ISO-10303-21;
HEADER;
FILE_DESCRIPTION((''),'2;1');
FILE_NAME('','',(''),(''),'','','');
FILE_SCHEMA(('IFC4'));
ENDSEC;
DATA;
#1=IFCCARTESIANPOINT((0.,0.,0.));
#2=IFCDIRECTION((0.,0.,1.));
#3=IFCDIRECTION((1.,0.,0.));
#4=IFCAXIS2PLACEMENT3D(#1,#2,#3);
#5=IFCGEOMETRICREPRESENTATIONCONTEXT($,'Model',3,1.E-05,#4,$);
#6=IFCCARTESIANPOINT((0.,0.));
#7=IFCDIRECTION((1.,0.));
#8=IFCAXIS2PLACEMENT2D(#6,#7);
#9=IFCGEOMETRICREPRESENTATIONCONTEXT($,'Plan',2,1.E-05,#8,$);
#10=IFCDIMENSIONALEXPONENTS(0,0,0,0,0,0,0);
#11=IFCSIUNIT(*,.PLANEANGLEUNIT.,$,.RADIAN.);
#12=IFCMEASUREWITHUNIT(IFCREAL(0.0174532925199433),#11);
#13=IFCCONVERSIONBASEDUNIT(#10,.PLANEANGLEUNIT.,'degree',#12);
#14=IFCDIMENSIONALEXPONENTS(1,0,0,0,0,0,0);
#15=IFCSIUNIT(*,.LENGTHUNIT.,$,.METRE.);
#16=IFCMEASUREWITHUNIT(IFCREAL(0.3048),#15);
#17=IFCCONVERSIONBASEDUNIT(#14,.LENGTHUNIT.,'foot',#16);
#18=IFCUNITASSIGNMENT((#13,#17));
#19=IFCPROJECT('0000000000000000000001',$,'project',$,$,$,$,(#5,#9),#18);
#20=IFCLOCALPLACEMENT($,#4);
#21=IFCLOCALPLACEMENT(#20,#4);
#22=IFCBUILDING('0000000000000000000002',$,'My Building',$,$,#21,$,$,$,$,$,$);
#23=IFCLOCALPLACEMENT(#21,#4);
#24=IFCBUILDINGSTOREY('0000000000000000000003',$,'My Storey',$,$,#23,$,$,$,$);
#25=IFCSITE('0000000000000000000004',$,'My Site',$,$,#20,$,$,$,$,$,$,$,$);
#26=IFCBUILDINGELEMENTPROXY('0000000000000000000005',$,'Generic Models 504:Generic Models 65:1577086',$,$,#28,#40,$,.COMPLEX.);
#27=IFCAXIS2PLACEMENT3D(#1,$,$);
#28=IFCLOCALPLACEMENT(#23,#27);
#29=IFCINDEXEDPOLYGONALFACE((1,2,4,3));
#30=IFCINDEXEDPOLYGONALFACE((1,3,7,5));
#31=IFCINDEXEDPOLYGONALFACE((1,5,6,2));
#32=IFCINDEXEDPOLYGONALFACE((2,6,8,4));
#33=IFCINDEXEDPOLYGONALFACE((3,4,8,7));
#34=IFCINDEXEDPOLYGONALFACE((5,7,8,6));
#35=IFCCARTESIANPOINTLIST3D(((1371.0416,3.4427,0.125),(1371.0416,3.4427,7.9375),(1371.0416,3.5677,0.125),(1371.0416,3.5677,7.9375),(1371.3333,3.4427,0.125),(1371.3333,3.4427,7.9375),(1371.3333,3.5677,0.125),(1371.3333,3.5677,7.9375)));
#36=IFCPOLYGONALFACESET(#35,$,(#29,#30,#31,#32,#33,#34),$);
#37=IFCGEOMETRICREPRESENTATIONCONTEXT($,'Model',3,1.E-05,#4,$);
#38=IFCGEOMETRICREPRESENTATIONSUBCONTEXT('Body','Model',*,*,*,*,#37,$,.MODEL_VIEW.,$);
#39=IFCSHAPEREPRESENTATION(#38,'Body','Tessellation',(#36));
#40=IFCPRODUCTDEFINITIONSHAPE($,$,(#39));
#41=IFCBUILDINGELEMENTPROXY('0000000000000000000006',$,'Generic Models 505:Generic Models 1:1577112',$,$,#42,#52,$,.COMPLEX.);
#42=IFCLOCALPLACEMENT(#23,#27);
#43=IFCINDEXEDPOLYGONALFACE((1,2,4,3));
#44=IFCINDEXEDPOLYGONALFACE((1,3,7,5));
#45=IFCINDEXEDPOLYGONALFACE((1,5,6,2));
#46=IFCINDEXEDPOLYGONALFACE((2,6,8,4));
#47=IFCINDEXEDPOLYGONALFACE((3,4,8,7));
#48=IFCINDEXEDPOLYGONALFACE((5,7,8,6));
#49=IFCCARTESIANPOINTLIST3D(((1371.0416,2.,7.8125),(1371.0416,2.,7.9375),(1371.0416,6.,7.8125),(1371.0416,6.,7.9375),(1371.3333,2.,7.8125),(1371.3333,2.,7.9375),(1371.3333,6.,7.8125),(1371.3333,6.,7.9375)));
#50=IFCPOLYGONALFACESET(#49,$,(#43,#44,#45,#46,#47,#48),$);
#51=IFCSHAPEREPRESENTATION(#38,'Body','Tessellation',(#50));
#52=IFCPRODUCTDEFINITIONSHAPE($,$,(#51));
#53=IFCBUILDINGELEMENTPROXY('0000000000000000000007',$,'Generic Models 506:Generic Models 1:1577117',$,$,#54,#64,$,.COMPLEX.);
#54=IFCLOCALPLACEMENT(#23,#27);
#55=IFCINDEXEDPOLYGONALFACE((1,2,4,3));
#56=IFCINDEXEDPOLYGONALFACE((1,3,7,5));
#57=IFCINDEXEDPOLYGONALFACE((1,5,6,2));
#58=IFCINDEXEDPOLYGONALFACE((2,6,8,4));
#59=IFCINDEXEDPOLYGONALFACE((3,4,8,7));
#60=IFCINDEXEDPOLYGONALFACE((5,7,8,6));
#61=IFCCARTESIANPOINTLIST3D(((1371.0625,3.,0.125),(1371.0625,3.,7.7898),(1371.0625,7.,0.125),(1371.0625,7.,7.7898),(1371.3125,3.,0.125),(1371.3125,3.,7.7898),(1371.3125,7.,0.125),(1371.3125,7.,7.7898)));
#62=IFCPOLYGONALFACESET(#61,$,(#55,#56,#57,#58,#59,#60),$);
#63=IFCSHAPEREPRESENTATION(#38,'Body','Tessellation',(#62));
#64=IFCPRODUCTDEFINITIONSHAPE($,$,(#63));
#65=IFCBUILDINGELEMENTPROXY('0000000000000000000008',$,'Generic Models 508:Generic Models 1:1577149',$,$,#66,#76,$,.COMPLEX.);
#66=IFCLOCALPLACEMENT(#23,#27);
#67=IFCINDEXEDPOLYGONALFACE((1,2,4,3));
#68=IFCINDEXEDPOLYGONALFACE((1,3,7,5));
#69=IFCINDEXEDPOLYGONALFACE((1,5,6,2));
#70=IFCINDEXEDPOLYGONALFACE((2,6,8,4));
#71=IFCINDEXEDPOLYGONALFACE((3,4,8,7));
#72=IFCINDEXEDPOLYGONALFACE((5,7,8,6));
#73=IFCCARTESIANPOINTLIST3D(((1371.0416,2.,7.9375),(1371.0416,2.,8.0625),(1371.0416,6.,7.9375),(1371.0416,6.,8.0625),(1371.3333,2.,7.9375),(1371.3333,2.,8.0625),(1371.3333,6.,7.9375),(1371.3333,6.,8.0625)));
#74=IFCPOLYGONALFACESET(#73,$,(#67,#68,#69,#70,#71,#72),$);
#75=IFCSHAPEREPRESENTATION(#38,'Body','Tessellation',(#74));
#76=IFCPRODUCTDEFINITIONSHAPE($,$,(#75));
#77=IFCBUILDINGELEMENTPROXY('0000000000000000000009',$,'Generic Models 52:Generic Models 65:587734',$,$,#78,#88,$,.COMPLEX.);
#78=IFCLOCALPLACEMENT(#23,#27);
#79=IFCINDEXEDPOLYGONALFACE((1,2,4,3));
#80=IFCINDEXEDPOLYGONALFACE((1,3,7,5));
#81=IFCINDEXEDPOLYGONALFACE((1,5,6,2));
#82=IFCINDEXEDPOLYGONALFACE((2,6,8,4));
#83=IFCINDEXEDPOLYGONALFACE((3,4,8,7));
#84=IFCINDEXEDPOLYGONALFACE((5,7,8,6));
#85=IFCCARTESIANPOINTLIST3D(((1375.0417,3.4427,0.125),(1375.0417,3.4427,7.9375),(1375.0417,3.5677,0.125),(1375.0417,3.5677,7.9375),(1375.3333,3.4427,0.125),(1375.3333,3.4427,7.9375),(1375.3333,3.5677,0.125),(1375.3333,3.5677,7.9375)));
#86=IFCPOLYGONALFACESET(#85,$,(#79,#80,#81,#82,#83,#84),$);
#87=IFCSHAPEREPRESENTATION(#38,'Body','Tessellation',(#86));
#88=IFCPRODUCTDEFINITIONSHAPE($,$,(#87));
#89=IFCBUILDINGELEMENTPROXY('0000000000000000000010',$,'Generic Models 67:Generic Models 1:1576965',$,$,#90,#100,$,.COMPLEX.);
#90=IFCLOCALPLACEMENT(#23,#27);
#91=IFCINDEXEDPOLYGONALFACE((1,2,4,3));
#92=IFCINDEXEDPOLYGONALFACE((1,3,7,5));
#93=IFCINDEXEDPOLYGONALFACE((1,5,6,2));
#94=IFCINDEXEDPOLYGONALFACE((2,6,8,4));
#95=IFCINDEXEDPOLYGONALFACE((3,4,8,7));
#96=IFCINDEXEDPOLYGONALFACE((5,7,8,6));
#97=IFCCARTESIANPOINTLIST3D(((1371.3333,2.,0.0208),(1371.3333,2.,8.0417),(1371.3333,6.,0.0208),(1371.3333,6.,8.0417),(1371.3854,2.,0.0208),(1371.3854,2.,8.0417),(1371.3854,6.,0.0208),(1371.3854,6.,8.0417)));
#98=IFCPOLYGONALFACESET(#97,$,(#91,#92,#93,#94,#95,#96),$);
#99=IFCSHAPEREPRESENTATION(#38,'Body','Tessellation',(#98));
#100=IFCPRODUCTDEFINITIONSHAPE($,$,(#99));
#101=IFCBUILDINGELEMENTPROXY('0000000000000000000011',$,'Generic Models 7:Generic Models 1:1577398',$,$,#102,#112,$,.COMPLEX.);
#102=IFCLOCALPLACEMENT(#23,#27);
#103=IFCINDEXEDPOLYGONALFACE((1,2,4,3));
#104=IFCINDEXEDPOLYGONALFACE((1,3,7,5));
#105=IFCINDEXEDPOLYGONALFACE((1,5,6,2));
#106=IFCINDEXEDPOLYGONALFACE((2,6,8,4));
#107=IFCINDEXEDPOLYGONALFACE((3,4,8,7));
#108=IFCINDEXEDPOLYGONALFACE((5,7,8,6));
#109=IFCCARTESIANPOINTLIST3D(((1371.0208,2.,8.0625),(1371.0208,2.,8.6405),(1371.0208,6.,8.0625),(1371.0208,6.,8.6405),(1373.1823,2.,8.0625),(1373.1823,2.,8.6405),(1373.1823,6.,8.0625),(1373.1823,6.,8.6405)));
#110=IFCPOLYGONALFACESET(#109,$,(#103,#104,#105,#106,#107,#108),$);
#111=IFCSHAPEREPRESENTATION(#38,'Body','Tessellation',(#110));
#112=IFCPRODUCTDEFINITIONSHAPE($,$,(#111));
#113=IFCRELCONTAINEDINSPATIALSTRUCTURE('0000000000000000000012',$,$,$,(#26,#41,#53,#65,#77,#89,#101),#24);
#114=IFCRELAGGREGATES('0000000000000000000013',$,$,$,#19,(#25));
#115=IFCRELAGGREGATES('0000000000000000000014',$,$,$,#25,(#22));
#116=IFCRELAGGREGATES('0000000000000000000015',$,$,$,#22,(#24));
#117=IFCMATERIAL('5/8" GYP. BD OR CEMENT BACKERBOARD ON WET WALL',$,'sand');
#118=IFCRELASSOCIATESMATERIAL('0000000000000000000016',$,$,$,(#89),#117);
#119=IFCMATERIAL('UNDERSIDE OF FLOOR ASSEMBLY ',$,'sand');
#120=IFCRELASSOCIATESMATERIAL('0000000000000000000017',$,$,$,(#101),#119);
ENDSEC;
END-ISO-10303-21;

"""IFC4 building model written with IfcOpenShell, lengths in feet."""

from ifc_helpers import new_model, entity, si_unit, converted_unit, frame, origin_with_axes, origin_2d_with_axis, place, context, subcontext, project, spatial, polyline, outline, extrude, material, element, save


model = new_model("IFC4")

# Units and contexts
model_context_1 = context("Model", 3, precision=1e-05, world=origin_with_axes())
plan_context = context("Plan", 2, precision=1e-05, world=origin_2d_with_axis())
model_context_2 = context("Model", 3, precision=1e-05, world=origin_with_axes())
body_context = subcontext(model_context_2, "Body", "Model", "MODEL_VIEW")
ifc_project = project(units=[converted_unit("PLANEANGLEUNIT", "degree", entity("IfcReal", 0.0174532925199433), si_unit("PLANEANGLEUNIT", "RADIAN"), dimensions=[0, 0, 0, 0, 0, 0, 0]), converted_unit("LENGTHUNIT", "foot", entity("IfcReal", 0.3048), si_unit("LENGTHUNIT", "METRE"), dimensions=[1, 0, 0, 0, 0, 0, 0])], contexts=[model_context_1, plan_context])

# Site, building, storey
site_placement = place(None, origin_with_axes())
site = spatial("IfcSite", under=ifc_project, at=site_placement, Name="My Site")
building_placement = place(site_placement, origin_with_axes())
building = spatial("IfcBuilding", under=site, at=building_placement, Name="My Building")
storey_placement = place(building_placement, origin_with_axes())
storey = spatial("IfcBuildingStorey", under=building, at=storey_placement, Name="My Storey")

# Building element proxies
ifc_material_1 = material(Name="UNDERSIDE OF FLOOR ASSEMBLY ", Category="sand")
proxy_1_placement = place(storey_placement, frame((1371.0416, 3.4427, 0.125), z_axis=(1.0, 0.0, 0.0), x_axis=(0.0, 0.0, -1.0)))
element("IfcBuildingElementProxy", 1, at=proxy_1_placement, inside=storey, Name="Generic Models 504:Generic Models 65:1577086", PredefinedType="COMPLEX", context=body_context, shape_type="SweptSolid", body=[
    extrude(outline(polyline([(-3.9062, -0.0625), (3.9062, -0.0625), (3.9062, 0.0625), (-3.9062, 0.0625), (-3.9062, -0.0625)])), frame((-3.9062, 0.0625, 0.0), z_axis=(0.0, 0.0, -1.0), x_axis=(1.0, 0.0, 0.0)), (0.0, 0.0, -1.0), 0.2917),
])
proxy_2_placement = place(storey_placement, frame((1371.0416, 6.0, 7.8125), z_axis=(0.0, -1.0, 0.0), x_axis=(0.0, 0.0, -1.0)))
element("IfcBuildingElementProxy", 2, at=proxy_2_placement, inside=storey, Name="Generic Models 505:Generic Models 1:1577112", PredefinedType="COMPLEX", context=body_context, shape_type="SweptSolid", body=[
    extrude(outline(polyline([(-0.0625, -0.1458), (0.0625, -0.1458), (0.0625, 0.1458), (-0.0625, 0.1458), (-0.0625, -0.1458)])), frame((-0.0625, 0.1458, 0.0), z_axis=(0.0, 0.0, -1.0), x_axis=(1.0, 0.0, 0.0)), (0.0, 0.0, -1.0), 4.0),
])
proxy_3_placement = place(storey_placement, frame((1371.0625, 3.0, 0.125), z_axis=(0.0, 1.0, 0.0), x_axis=(0.0, 0.0, -1.0)))
element("IfcBuildingElementProxy", 3, at=proxy_3_placement, inside=storey, Name="Generic Models 506:Generic Models 1:1577117", PredefinedType="COMPLEX", context=body_context, shape_type="SweptSolid", body=[
    extrude(outline(polyline([(-3.8324, -0.125), (3.8324, -0.125), (3.8324, 0.125), (-3.8324, 0.125), (-3.8324, -0.125)])), frame((-3.8324, -0.125, 0.0), z_axis=(0.0, 0.0, -1.0), x_axis=(-1.0, 0.0, 0.0)), (0.0, 0.0, -1.0), 4.0),
])
proxy_4_placement = place(storey_placement, frame((1371.0416, 6.0, 7.9375), z_axis=(0.0, -1.0, 0.0), x_axis=(0.0, 0.0, -1.0)))
element("IfcBuildingElementProxy", 4, at=proxy_4_placement, inside=storey, Name="Generic Models 508:Generic Models 1:1577149", PredefinedType="COMPLEX", context=body_context, shape_type="SweptSolid", body=[
    extrude(outline(polyline([(-0.0625, -0.1458), (0.0625, -0.1458), (0.0625, 0.1458), (-0.0625, 0.1458), (-0.0625, -0.1458)])), frame((-0.0625, 0.1458, 0.0), z_axis=(0.0, 0.0, -1.0), x_axis=(1.0, 0.0, 0.0)), (0.0, 0.0, -1.0), 4.0),
])
proxy_5_placement = place(storey_placement, frame((1375.0417, 3.4427, 0.125), z_axis=(1.0, 0.0, 0.0), x_axis=(0.0, 0.0, -1.0)))
element("IfcBuildingElementProxy", 5, at=proxy_5_placement, inside=storey, Name="Generic Models 52:Generic Models 65:587734", PredefinedType="COMPLEX", context=body_context, shape_type="SweptSolid", body=[
    extrude(outline(polyline([(-3.9062, -0.0625), (3.9062, -0.0625), (3.9062, 0.0625), (-3.9062, 0.0625), (-3.9062, -0.0625)])), frame((-3.9062, 0.0625, 0.0), z_axis=(0.0, 0.0, -1.0), x_axis=(-1.0, 0.0, 0.0)), (0.0, 0.0, -1.0), 0.2917),
])
ifc_material_2 = material(Name="5/8\" GYP. BD OR CEMENT BACKERBOARD ON WET WALL", Category="sand")
proxy_6_placement = place(storey_placement, frame((1371.3333, 6.0, 0.0208), z_axis=(0.0, -1.0, 0.0), x_axis=(0.0, 0.0, -1.0)))
element("IfcBuildingElementProxy", 6, at=proxy_6_placement, inside=storey, material=ifc_material_2, Name="Generic Models 67:Generic Models 1:1576965", PredefinedType="COMPLEX", context=body_context, shape_type="SweptSolid", body=[
    extrude(outline(polyline([(-0.026, -4.0104), (0.026, -4.0104), (0.026, 4.0104), (-0.026, 4.0104), (-0.026, -4.0104)])), frame((-4.0104, 0.026, 0.0), z_axis=(0.0, 0.0, -1.0), x_axis=(0.0, 1.0, 0.0)), (0.0, 0.0, -1.0), 4.0),
])
proxy_7_placement = place(storey_placement, frame((1371.0208, 6.0, 8.0625), z_axis=(0.0, -1.0, 0.0), x_axis=(0.0, 0.0, -1.0)))
element("IfcBuildingElementProxy", 7, at=proxy_7_placement, inside=storey, material=ifc_material_1, Name="Generic Models 7:Generic Models 1:1577398", PredefinedType="COMPLEX", context=body_context, shape_type="SweptSolid", body=[
    extrude(outline(polyline([(-0.289, -1.0807), (0.289, -1.0807), (0.289, 1.0807), (-0.289, 1.0807), (-0.289, -1.0807)])), frame((-0.289, 1.0807, 0.0), z_axis=(0.0, 0.0, -1.0), x_axis=(-1.0, 0.0, 0.0)), (0.0, 0.0, -1.0), 4.0),
])

save(model, "model.ifc")
